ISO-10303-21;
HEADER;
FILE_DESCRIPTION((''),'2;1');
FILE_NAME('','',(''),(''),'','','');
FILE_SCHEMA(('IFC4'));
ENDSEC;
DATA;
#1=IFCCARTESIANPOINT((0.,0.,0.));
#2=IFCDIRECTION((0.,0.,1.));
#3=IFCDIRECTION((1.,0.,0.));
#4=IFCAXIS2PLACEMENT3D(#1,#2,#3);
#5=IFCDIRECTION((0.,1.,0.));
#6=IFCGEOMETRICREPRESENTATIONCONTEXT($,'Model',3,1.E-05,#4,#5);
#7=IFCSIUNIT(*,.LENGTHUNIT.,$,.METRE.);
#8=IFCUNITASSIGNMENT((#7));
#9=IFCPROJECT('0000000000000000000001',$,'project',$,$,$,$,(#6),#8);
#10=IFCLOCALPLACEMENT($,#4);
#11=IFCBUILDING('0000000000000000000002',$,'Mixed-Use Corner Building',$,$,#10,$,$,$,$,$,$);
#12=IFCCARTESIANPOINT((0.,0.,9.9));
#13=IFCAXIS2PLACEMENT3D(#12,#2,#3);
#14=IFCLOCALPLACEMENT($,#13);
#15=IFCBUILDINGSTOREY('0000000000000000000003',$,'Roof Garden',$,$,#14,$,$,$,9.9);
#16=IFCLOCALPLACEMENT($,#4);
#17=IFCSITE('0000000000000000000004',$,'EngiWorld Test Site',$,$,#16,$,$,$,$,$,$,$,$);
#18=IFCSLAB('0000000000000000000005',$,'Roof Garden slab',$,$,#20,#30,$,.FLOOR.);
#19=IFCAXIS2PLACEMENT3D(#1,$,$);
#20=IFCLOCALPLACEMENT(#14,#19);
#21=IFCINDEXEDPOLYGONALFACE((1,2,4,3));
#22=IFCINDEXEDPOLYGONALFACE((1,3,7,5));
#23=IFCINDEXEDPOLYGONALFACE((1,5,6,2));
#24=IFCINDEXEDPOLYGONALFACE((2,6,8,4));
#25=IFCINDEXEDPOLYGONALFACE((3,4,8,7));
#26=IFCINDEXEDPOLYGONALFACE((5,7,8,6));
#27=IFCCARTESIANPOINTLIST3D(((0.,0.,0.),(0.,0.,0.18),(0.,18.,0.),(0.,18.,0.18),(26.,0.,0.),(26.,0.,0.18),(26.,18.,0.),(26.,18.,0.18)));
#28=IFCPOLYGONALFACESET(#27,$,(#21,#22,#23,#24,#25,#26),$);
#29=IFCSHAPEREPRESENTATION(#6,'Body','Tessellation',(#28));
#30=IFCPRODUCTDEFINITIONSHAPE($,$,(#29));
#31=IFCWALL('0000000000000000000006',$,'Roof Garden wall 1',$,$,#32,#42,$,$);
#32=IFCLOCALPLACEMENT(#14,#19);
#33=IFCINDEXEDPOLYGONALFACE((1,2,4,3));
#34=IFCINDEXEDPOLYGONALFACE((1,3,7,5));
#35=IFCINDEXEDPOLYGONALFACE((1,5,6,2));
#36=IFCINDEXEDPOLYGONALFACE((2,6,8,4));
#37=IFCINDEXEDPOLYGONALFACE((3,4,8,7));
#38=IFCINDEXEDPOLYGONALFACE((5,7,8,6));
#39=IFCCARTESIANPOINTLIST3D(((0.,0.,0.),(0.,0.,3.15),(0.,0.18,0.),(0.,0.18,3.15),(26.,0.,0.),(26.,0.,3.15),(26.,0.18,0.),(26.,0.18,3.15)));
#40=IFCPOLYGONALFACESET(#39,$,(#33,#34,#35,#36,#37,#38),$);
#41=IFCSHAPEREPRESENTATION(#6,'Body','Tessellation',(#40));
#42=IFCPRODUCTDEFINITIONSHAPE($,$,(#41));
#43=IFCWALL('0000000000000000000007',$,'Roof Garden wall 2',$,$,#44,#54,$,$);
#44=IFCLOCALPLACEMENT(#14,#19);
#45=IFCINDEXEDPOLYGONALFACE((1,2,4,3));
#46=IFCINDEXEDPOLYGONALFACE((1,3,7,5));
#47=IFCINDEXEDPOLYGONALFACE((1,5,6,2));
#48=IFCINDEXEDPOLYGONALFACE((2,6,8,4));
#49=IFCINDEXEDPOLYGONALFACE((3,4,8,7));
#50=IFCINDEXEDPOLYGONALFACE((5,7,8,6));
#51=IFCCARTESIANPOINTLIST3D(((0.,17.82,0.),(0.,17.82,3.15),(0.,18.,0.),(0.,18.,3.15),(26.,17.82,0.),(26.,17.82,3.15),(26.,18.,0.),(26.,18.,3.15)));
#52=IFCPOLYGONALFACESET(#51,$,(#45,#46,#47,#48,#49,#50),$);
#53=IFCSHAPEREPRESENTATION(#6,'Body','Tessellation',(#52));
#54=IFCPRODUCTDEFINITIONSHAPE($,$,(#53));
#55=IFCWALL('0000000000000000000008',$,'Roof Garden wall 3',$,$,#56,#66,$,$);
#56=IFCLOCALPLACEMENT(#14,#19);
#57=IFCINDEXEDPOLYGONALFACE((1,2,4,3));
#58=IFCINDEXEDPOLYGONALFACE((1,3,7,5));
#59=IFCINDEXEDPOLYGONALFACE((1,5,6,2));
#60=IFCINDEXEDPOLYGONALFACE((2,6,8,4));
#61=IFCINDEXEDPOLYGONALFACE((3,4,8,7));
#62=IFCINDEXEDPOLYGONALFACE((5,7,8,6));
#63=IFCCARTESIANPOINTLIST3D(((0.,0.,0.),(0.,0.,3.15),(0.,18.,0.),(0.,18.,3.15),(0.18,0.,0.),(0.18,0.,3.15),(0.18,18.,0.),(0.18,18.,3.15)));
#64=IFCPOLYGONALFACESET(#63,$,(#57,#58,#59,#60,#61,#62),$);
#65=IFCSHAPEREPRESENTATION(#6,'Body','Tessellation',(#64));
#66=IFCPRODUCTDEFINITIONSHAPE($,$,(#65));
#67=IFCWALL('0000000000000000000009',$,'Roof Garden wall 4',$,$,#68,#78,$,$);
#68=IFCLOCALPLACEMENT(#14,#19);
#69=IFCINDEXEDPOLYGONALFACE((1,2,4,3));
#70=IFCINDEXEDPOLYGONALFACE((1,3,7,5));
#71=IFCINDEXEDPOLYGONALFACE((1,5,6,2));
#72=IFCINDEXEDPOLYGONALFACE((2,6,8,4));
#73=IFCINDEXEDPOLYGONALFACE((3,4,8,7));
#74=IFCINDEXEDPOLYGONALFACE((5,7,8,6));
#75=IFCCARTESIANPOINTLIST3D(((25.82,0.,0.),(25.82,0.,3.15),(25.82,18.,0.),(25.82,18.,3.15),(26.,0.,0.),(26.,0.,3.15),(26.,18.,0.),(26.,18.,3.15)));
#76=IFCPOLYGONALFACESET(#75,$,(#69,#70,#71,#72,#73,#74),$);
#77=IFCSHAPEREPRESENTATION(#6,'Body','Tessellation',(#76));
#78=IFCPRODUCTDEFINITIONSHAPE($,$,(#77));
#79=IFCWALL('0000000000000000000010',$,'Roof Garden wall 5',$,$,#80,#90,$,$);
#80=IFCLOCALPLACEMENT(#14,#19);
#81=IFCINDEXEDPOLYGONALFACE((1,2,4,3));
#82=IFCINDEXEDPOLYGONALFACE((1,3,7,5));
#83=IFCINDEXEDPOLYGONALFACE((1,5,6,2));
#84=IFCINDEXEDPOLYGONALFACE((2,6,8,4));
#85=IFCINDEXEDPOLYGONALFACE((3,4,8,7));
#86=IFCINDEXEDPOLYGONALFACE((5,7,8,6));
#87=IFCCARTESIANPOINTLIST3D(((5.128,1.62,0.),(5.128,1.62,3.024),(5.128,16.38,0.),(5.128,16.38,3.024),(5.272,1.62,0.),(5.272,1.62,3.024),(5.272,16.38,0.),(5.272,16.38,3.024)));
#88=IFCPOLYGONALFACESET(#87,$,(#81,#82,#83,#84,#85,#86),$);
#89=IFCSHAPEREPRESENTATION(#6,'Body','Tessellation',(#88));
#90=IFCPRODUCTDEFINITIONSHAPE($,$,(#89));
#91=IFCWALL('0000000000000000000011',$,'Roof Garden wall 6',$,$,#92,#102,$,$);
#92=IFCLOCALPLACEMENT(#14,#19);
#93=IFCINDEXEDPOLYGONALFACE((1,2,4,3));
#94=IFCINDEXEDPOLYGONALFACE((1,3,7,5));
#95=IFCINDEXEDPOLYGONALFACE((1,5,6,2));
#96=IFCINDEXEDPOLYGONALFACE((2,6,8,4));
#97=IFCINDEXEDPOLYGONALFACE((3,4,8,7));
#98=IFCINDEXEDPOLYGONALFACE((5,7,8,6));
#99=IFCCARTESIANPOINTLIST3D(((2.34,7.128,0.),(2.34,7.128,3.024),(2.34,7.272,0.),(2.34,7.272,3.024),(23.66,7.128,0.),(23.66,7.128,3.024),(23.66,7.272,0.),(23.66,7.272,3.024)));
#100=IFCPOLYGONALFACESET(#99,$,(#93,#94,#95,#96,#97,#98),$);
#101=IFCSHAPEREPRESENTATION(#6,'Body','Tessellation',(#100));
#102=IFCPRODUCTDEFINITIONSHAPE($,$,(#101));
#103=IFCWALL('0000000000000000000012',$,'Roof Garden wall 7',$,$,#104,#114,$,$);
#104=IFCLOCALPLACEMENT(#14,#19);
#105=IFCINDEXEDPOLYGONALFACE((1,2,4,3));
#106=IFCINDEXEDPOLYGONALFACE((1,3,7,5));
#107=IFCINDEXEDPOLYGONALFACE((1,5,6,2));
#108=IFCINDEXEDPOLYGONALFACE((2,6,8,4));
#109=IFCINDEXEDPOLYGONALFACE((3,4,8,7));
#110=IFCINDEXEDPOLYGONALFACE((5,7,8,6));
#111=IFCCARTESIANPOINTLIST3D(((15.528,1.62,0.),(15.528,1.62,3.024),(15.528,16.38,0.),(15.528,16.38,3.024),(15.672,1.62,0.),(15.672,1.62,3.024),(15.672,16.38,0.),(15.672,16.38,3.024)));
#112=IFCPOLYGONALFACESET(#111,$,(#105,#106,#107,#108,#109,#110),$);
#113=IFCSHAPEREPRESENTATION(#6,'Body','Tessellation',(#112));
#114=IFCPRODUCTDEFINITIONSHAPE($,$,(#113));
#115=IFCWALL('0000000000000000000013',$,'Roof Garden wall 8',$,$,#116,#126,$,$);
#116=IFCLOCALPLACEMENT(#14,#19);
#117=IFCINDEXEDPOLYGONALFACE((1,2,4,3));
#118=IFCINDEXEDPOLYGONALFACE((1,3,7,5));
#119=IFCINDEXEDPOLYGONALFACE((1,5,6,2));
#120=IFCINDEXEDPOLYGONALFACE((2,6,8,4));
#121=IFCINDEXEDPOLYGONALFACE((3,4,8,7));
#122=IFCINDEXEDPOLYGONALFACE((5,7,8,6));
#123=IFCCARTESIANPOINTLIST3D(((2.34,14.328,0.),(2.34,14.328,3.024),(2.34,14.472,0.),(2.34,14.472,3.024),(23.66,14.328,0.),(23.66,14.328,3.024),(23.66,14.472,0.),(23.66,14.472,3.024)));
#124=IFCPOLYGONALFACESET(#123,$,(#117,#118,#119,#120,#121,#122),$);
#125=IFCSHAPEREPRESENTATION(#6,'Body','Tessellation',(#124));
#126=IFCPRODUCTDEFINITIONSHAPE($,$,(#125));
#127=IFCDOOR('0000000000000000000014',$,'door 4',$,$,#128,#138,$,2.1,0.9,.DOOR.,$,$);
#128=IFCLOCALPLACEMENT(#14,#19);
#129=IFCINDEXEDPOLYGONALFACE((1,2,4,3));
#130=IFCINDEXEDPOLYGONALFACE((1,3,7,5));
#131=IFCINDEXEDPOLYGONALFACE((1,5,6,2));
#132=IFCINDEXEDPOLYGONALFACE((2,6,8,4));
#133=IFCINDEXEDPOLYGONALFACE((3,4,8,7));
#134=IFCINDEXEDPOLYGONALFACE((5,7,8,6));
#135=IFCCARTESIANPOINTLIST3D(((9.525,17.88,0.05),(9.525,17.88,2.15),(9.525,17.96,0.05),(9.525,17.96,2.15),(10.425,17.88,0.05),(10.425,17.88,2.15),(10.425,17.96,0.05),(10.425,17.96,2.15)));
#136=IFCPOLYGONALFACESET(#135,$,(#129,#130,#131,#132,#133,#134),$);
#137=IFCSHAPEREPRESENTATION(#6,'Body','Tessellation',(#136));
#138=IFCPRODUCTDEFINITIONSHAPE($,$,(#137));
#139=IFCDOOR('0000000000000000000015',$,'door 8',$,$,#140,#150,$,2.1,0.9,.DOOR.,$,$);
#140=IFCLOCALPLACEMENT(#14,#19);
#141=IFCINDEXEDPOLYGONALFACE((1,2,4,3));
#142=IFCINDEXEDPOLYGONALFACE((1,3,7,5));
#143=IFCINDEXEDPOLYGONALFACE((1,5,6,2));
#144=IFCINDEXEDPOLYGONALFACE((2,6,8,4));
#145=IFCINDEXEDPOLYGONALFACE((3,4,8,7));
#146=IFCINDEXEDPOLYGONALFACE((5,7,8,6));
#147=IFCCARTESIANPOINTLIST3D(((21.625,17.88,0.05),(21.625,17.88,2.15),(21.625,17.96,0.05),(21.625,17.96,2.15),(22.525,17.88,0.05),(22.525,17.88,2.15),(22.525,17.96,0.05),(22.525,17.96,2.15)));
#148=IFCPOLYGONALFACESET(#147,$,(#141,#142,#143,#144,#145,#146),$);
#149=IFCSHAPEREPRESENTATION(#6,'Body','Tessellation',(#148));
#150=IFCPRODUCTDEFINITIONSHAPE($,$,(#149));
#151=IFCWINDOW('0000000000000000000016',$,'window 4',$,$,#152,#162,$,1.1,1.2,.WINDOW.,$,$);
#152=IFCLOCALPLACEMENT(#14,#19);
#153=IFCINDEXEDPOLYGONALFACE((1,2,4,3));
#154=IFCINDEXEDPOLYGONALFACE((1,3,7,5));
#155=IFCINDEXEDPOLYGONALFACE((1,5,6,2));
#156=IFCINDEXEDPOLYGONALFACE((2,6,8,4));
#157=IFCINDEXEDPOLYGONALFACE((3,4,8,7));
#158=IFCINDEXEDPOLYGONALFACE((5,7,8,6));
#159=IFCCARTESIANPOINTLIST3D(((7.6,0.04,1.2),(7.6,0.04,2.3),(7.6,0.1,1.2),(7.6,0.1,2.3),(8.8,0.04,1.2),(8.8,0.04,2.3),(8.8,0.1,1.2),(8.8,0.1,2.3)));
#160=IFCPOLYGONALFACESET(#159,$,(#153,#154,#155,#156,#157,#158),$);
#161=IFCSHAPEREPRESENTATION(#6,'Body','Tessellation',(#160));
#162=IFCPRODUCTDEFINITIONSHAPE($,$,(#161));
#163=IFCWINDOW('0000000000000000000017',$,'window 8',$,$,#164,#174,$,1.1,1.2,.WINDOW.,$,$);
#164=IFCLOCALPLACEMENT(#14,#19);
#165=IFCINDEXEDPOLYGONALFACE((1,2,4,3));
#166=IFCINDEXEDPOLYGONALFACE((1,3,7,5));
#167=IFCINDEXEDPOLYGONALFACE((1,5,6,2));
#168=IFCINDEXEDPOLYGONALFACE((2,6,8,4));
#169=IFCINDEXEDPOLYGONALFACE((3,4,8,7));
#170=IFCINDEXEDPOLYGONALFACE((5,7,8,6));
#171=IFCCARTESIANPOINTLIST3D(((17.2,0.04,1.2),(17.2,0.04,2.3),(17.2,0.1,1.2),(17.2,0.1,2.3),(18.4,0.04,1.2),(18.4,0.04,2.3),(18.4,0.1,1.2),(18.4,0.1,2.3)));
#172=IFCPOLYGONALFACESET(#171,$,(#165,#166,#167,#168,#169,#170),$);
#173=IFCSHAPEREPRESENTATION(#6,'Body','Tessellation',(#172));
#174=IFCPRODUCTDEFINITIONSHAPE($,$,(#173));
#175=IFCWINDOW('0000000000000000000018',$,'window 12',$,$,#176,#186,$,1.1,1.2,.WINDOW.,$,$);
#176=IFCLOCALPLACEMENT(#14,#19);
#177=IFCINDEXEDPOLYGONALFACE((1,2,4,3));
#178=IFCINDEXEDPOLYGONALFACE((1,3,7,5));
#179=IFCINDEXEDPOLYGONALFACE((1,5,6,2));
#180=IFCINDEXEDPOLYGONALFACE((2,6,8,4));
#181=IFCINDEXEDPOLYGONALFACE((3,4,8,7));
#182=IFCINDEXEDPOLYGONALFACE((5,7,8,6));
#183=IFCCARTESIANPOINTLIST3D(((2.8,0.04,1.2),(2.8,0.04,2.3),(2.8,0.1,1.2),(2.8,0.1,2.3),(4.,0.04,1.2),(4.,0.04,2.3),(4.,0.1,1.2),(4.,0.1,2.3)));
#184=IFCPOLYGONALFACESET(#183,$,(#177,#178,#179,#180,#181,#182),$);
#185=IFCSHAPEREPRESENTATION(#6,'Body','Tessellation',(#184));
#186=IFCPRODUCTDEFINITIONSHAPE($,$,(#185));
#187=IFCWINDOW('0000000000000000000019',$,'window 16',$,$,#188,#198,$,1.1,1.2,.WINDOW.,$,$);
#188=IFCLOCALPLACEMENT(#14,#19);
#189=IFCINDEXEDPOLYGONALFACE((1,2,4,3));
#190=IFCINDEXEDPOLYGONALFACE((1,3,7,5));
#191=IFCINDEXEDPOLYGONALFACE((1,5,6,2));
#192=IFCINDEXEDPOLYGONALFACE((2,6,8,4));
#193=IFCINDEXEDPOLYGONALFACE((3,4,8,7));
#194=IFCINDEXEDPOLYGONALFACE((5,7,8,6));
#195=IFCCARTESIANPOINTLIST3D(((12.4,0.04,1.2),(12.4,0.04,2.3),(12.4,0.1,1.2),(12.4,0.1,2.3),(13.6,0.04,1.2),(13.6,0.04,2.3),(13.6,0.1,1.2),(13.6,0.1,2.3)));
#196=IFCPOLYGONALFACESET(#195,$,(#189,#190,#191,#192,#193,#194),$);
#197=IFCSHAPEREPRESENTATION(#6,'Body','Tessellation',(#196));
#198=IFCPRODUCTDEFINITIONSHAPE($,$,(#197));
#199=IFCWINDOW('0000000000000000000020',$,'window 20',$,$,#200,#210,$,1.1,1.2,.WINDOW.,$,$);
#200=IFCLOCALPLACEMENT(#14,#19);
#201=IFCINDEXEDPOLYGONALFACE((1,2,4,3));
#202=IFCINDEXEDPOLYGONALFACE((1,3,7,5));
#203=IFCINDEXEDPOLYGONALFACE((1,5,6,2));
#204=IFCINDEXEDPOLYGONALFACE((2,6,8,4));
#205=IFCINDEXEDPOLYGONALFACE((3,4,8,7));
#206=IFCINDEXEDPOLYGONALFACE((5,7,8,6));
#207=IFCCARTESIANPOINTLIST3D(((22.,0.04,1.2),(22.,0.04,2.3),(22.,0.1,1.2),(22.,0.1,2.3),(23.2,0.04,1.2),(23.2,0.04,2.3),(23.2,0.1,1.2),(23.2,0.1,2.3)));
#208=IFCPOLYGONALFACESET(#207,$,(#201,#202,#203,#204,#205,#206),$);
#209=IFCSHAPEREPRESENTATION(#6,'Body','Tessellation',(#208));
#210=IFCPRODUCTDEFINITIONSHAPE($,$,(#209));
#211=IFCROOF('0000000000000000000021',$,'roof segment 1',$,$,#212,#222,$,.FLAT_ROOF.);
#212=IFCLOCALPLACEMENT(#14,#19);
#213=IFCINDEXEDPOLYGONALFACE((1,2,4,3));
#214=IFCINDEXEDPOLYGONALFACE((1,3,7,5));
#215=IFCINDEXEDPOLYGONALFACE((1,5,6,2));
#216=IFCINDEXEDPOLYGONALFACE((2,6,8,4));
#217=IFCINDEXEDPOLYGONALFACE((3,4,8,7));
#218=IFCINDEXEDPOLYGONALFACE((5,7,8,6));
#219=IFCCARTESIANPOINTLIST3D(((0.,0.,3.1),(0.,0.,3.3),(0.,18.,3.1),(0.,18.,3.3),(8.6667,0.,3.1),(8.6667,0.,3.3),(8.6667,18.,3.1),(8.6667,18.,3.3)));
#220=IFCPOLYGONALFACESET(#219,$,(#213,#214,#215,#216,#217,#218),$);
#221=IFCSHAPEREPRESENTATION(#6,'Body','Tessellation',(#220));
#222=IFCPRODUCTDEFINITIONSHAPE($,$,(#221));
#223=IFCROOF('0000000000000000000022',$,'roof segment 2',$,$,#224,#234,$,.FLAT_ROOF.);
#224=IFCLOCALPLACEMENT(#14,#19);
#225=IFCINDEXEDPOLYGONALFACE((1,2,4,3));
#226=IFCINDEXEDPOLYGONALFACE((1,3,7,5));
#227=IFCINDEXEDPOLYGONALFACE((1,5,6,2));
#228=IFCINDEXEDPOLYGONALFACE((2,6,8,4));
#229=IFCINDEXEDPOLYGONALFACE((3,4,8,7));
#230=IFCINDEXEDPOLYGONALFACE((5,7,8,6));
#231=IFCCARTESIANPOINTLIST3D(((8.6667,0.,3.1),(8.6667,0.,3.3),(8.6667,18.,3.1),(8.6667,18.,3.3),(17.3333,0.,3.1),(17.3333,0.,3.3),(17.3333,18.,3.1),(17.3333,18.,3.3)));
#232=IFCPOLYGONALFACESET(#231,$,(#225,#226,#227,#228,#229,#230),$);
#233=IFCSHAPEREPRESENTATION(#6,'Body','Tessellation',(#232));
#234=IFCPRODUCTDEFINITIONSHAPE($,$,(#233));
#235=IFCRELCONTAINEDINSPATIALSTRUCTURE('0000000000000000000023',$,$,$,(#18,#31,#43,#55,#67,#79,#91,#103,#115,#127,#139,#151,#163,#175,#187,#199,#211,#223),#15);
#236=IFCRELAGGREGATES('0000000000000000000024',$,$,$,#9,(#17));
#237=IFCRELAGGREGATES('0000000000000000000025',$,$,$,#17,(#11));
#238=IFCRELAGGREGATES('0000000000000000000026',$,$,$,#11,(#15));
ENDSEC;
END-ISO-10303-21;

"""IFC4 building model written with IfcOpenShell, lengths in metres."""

from ifc_helpers import new_model, si_unit, direction, frame, origin_with_axes, origin_2d_with_axis, place, context, project, spatial, rectangle, extrude, element, save


model = new_model("IFC4")

# Units and contexts
model_context = context("Model", 3, precision=1e-05, world=origin_with_axes(), true_north=direction((0.0, 1.0, 0.0)))
ifc_project = project(units=[si_unit("LENGTHUNIT", "METRE")], contexts=[model_context])

# Site, building, storey
site_placement = place(None, origin_with_axes())
site = spatial("IfcSite", under=ifc_project, at=site_placement, Name="EngiWorld Test Site")
building_placement = place(None, origin_with_axes())
building = spatial("IfcBuilding", under=site, at=building_placement, Name="Mixed-Use Corner Building")
storey_placement = place(None, frame((0.0, 0.0, 9.9), z_axis=(0.0, 0.0, 1.0), x_axis=(1.0, 0.0, 0.0)))
storey = spatial("IfcBuildingStorey", under=building, at=storey_placement, Name="Roof Garden", Elevation=9.9)

# Slab
slab_placement = place(None, frame((13.0, 9.0, 9.9), z_axis=(0.0, 0.0, 1.0), x_axis=(1.0, 0.0, 0.0)))
element("IfcSlab", 1, at=slab_placement, inside=storey, Name="Roof Garden slab", PredefinedType="FLOOR", context=model_context, shape_type="SweptSolid", body=[
    extrude(rectangle(XDim=26.0, YDim=18.0, at=origin_2d_with_axis()), origin_with_axes(), (0.0, 0.0, 1.0), 0.18),
])

# Walls
for number, where, z_axis, x_axis, name in (
    (2, (13.0, 0.09, 9.9), (0.0, 0.0, 1.0), (1.0, 0.0, 0.0), "Roof Garden wall 1"),
    (3, (13.0, 17.91, 9.9), (0.0, 0.0, 1.0), (1.0, 0.0, 0.0), "Roof Garden wall 2"),
):
    element("IfcWall", number, at=place(None, frame(where, z_axis=z_axis, x_axis=x_axis)), inside=storey, Name=name, context=model_context, shape_type="SweptSolid", body=[
        extrude(rectangle(XDim=26.0, YDim=0.18, at=origin_2d_with_axis()), origin_with_axes(), (0.0, 0.0, 1.0), 3.15),
    ])
for number, where, z_axis, x_axis, name in (
    (4, (0.09, 9.0, 9.9), (0.0, 0.0, 1.0), (1.0, 0.0, 0.0), "Roof Garden wall 3"),
    (5, (25.91, 9.0, 9.9), (0.0, 0.0, 1.0), (1.0, 0.0, 0.0), "Roof Garden wall 4"),
):
    element("IfcWall", number, at=place(None, frame(where, z_axis=z_axis, x_axis=x_axis)), inside=storey, Name=name, context=model_context, shape_type="SweptSolid", body=[
        extrude(rectangle(XDim=0.18, YDim=18.0, at=origin_2d_with_axis()), origin_with_axes(), (0.0, 0.0, 1.0), 3.15),
    ])
wall_1_placement = place(None, frame((5.2, 9.0, 9.9), z_axis=(0.0, 0.0, 1.0), x_axis=(1.0, 0.0, 0.0)))
element("IfcWall", 6, at=wall_1_placement, inside=storey, Name="Roof Garden wall 5", context=model_context, shape_type="SweptSolid", body=[
    extrude(rectangle(XDim=0.144, YDim=14.76, at=origin_2d_with_axis()), origin_with_axes(), (0.0, 0.0, 1.0), 3.024),
])
wall_2_placement = place(None, frame((13.0, 7.2, 9.9), z_axis=(0.0, 0.0, 1.0), x_axis=(1.0, 0.0, 0.0)))
element("IfcWall", 7, at=wall_2_placement, inside=storey, Name="Roof Garden wall 6", context=model_context, shape_type="SweptSolid", body=[
    extrude(rectangle(XDim=21.32, YDim=0.144, at=origin_2d_with_axis()), origin_with_axes(), (0.0, 0.0, 1.0), 3.024),
])
wall_3_placement = place(None, frame((15.6, 9.0, 9.9), z_axis=(0.0, 0.0, 1.0), x_axis=(1.0, 0.0, 0.0)))
element("IfcWall", 8, at=wall_3_placement, inside=storey, Name="Roof Garden wall 7", context=model_context, shape_type="SweptSolid", body=[
    extrude(rectangle(XDim=0.144, YDim=14.76, at=origin_2d_with_axis()), origin_with_axes(), (0.0, 0.0, 1.0), 3.024),
])
wall_4_placement = place(None, frame((13.0, 14.4, 9.9), z_axis=(0.0, 0.0, 1.0), x_axis=(1.0, 0.0, 0.0)))
element("IfcWall", 9, at=wall_4_placement, inside=storey, Name="Roof Garden wall 8", context=model_context, shape_type="SweptSolid", body=[
    extrude(rectangle(XDim=21.32, YDim=0.144, at=origin_2d_with_axis()), origin_with_axes(), (0.0, 0.0, 1.0), 3.024),
])

# Doors
for number, where, z_axis, x_axis, name in (
    (10, (9.975, 17.92, 9.95), (0.0, 0.0, 1.0), (1.0, 0.0, 0.0), "door 4"),
    (11, (22.075, 17.92, 9.95), (0.0, 0.0, 1.0), (1.0, 0.0, 0.0), "door 8"),
):
    element("IfcDoor", number, at=place(None, frame(where, z_axis=z_axis, x_axis=x_axis)), inside=storey, Name=name, OverallHeight=2.1, OverallWidth=0.9, PredefinedType="DOOR", context=model_context, shape_type="SweptSolid", body=[
        extrude(rectangle(XDim=0.9, YDim=0.08, at=origin_2d_with_axis()), origin_with_axes(), (0.0, 0.0, 1.0), 2.1),
    ])

# Windows
for number, where, z_axis, x_axis, name in (
    (12, (8.2, 0.07, 11.1), (0.0, 0.0, 1.0), (1.0, 0.0, 0.0), "window 4"),
    (13, (17.8, 0.07, 11.1), (0.0, 0.0, 1.0), (1.0, 0.0, 0.0), "window 8"),
    (14, (3.4, 0.07, 11.1), (0.0, 0.0, 1.0), (1.0, 0.0, 0.0), "window 12"),
    (15, (13.0, 0.07, 11.1), (0.0, 0.0, 1.0), (1.0, 0.0, 0.0), "window 16"),
    (16, (22.6, 0.07, 11.1), (0.0, 0.0, 1.0), (1.0, 0.0, 0.0), "window 20"),
):
    element("IfcWindow", number, at=place(None, frame(where, z_axis=z_axis, x_axis=x_axis)), inside=storey, Name=name, OverallHeight=1.1, OverallWidth=1.2, PredefinedType="WINDOW", context=model_context, shape_type="SweptSolid", body=[
        extrude(rectangle(XDim=1.2, YDim=0.06, at=origin_2d_with_axis()), origin_with_axes(), (0.0, 0.0, 1.0), 1.1),
    ])

# Roofs
for number, where, z_axis, x_axis, name in (
    (17, (4.3333, 9.0, 13.0), (0.0, 0.0, 1.0), (1.0, 0.0, 0.0), "roof segment 1"),
    (18, (13.0, 9.0, 13.0), (0.0, 0.0, 1.0), (1.0, 0.0, 0.0), "roof segment 2"),
):
    element("IfcRoof", number, at=place(None, frame(where, z_axis=z_axis, x_axis=x_axis)), inside=storey, Name=name, PredefinedType="FLAT_ROOF", context=model_context, shape_type="SweptSolid", body=[
        extrude(rectangle(XDim=8.6667, YDim=18.0, at=origin_2d_with_axis()), origin_with_axes(), (0.0, 0.0, 1.0), 0.2),
    ])

save(model, "model.ifc")
